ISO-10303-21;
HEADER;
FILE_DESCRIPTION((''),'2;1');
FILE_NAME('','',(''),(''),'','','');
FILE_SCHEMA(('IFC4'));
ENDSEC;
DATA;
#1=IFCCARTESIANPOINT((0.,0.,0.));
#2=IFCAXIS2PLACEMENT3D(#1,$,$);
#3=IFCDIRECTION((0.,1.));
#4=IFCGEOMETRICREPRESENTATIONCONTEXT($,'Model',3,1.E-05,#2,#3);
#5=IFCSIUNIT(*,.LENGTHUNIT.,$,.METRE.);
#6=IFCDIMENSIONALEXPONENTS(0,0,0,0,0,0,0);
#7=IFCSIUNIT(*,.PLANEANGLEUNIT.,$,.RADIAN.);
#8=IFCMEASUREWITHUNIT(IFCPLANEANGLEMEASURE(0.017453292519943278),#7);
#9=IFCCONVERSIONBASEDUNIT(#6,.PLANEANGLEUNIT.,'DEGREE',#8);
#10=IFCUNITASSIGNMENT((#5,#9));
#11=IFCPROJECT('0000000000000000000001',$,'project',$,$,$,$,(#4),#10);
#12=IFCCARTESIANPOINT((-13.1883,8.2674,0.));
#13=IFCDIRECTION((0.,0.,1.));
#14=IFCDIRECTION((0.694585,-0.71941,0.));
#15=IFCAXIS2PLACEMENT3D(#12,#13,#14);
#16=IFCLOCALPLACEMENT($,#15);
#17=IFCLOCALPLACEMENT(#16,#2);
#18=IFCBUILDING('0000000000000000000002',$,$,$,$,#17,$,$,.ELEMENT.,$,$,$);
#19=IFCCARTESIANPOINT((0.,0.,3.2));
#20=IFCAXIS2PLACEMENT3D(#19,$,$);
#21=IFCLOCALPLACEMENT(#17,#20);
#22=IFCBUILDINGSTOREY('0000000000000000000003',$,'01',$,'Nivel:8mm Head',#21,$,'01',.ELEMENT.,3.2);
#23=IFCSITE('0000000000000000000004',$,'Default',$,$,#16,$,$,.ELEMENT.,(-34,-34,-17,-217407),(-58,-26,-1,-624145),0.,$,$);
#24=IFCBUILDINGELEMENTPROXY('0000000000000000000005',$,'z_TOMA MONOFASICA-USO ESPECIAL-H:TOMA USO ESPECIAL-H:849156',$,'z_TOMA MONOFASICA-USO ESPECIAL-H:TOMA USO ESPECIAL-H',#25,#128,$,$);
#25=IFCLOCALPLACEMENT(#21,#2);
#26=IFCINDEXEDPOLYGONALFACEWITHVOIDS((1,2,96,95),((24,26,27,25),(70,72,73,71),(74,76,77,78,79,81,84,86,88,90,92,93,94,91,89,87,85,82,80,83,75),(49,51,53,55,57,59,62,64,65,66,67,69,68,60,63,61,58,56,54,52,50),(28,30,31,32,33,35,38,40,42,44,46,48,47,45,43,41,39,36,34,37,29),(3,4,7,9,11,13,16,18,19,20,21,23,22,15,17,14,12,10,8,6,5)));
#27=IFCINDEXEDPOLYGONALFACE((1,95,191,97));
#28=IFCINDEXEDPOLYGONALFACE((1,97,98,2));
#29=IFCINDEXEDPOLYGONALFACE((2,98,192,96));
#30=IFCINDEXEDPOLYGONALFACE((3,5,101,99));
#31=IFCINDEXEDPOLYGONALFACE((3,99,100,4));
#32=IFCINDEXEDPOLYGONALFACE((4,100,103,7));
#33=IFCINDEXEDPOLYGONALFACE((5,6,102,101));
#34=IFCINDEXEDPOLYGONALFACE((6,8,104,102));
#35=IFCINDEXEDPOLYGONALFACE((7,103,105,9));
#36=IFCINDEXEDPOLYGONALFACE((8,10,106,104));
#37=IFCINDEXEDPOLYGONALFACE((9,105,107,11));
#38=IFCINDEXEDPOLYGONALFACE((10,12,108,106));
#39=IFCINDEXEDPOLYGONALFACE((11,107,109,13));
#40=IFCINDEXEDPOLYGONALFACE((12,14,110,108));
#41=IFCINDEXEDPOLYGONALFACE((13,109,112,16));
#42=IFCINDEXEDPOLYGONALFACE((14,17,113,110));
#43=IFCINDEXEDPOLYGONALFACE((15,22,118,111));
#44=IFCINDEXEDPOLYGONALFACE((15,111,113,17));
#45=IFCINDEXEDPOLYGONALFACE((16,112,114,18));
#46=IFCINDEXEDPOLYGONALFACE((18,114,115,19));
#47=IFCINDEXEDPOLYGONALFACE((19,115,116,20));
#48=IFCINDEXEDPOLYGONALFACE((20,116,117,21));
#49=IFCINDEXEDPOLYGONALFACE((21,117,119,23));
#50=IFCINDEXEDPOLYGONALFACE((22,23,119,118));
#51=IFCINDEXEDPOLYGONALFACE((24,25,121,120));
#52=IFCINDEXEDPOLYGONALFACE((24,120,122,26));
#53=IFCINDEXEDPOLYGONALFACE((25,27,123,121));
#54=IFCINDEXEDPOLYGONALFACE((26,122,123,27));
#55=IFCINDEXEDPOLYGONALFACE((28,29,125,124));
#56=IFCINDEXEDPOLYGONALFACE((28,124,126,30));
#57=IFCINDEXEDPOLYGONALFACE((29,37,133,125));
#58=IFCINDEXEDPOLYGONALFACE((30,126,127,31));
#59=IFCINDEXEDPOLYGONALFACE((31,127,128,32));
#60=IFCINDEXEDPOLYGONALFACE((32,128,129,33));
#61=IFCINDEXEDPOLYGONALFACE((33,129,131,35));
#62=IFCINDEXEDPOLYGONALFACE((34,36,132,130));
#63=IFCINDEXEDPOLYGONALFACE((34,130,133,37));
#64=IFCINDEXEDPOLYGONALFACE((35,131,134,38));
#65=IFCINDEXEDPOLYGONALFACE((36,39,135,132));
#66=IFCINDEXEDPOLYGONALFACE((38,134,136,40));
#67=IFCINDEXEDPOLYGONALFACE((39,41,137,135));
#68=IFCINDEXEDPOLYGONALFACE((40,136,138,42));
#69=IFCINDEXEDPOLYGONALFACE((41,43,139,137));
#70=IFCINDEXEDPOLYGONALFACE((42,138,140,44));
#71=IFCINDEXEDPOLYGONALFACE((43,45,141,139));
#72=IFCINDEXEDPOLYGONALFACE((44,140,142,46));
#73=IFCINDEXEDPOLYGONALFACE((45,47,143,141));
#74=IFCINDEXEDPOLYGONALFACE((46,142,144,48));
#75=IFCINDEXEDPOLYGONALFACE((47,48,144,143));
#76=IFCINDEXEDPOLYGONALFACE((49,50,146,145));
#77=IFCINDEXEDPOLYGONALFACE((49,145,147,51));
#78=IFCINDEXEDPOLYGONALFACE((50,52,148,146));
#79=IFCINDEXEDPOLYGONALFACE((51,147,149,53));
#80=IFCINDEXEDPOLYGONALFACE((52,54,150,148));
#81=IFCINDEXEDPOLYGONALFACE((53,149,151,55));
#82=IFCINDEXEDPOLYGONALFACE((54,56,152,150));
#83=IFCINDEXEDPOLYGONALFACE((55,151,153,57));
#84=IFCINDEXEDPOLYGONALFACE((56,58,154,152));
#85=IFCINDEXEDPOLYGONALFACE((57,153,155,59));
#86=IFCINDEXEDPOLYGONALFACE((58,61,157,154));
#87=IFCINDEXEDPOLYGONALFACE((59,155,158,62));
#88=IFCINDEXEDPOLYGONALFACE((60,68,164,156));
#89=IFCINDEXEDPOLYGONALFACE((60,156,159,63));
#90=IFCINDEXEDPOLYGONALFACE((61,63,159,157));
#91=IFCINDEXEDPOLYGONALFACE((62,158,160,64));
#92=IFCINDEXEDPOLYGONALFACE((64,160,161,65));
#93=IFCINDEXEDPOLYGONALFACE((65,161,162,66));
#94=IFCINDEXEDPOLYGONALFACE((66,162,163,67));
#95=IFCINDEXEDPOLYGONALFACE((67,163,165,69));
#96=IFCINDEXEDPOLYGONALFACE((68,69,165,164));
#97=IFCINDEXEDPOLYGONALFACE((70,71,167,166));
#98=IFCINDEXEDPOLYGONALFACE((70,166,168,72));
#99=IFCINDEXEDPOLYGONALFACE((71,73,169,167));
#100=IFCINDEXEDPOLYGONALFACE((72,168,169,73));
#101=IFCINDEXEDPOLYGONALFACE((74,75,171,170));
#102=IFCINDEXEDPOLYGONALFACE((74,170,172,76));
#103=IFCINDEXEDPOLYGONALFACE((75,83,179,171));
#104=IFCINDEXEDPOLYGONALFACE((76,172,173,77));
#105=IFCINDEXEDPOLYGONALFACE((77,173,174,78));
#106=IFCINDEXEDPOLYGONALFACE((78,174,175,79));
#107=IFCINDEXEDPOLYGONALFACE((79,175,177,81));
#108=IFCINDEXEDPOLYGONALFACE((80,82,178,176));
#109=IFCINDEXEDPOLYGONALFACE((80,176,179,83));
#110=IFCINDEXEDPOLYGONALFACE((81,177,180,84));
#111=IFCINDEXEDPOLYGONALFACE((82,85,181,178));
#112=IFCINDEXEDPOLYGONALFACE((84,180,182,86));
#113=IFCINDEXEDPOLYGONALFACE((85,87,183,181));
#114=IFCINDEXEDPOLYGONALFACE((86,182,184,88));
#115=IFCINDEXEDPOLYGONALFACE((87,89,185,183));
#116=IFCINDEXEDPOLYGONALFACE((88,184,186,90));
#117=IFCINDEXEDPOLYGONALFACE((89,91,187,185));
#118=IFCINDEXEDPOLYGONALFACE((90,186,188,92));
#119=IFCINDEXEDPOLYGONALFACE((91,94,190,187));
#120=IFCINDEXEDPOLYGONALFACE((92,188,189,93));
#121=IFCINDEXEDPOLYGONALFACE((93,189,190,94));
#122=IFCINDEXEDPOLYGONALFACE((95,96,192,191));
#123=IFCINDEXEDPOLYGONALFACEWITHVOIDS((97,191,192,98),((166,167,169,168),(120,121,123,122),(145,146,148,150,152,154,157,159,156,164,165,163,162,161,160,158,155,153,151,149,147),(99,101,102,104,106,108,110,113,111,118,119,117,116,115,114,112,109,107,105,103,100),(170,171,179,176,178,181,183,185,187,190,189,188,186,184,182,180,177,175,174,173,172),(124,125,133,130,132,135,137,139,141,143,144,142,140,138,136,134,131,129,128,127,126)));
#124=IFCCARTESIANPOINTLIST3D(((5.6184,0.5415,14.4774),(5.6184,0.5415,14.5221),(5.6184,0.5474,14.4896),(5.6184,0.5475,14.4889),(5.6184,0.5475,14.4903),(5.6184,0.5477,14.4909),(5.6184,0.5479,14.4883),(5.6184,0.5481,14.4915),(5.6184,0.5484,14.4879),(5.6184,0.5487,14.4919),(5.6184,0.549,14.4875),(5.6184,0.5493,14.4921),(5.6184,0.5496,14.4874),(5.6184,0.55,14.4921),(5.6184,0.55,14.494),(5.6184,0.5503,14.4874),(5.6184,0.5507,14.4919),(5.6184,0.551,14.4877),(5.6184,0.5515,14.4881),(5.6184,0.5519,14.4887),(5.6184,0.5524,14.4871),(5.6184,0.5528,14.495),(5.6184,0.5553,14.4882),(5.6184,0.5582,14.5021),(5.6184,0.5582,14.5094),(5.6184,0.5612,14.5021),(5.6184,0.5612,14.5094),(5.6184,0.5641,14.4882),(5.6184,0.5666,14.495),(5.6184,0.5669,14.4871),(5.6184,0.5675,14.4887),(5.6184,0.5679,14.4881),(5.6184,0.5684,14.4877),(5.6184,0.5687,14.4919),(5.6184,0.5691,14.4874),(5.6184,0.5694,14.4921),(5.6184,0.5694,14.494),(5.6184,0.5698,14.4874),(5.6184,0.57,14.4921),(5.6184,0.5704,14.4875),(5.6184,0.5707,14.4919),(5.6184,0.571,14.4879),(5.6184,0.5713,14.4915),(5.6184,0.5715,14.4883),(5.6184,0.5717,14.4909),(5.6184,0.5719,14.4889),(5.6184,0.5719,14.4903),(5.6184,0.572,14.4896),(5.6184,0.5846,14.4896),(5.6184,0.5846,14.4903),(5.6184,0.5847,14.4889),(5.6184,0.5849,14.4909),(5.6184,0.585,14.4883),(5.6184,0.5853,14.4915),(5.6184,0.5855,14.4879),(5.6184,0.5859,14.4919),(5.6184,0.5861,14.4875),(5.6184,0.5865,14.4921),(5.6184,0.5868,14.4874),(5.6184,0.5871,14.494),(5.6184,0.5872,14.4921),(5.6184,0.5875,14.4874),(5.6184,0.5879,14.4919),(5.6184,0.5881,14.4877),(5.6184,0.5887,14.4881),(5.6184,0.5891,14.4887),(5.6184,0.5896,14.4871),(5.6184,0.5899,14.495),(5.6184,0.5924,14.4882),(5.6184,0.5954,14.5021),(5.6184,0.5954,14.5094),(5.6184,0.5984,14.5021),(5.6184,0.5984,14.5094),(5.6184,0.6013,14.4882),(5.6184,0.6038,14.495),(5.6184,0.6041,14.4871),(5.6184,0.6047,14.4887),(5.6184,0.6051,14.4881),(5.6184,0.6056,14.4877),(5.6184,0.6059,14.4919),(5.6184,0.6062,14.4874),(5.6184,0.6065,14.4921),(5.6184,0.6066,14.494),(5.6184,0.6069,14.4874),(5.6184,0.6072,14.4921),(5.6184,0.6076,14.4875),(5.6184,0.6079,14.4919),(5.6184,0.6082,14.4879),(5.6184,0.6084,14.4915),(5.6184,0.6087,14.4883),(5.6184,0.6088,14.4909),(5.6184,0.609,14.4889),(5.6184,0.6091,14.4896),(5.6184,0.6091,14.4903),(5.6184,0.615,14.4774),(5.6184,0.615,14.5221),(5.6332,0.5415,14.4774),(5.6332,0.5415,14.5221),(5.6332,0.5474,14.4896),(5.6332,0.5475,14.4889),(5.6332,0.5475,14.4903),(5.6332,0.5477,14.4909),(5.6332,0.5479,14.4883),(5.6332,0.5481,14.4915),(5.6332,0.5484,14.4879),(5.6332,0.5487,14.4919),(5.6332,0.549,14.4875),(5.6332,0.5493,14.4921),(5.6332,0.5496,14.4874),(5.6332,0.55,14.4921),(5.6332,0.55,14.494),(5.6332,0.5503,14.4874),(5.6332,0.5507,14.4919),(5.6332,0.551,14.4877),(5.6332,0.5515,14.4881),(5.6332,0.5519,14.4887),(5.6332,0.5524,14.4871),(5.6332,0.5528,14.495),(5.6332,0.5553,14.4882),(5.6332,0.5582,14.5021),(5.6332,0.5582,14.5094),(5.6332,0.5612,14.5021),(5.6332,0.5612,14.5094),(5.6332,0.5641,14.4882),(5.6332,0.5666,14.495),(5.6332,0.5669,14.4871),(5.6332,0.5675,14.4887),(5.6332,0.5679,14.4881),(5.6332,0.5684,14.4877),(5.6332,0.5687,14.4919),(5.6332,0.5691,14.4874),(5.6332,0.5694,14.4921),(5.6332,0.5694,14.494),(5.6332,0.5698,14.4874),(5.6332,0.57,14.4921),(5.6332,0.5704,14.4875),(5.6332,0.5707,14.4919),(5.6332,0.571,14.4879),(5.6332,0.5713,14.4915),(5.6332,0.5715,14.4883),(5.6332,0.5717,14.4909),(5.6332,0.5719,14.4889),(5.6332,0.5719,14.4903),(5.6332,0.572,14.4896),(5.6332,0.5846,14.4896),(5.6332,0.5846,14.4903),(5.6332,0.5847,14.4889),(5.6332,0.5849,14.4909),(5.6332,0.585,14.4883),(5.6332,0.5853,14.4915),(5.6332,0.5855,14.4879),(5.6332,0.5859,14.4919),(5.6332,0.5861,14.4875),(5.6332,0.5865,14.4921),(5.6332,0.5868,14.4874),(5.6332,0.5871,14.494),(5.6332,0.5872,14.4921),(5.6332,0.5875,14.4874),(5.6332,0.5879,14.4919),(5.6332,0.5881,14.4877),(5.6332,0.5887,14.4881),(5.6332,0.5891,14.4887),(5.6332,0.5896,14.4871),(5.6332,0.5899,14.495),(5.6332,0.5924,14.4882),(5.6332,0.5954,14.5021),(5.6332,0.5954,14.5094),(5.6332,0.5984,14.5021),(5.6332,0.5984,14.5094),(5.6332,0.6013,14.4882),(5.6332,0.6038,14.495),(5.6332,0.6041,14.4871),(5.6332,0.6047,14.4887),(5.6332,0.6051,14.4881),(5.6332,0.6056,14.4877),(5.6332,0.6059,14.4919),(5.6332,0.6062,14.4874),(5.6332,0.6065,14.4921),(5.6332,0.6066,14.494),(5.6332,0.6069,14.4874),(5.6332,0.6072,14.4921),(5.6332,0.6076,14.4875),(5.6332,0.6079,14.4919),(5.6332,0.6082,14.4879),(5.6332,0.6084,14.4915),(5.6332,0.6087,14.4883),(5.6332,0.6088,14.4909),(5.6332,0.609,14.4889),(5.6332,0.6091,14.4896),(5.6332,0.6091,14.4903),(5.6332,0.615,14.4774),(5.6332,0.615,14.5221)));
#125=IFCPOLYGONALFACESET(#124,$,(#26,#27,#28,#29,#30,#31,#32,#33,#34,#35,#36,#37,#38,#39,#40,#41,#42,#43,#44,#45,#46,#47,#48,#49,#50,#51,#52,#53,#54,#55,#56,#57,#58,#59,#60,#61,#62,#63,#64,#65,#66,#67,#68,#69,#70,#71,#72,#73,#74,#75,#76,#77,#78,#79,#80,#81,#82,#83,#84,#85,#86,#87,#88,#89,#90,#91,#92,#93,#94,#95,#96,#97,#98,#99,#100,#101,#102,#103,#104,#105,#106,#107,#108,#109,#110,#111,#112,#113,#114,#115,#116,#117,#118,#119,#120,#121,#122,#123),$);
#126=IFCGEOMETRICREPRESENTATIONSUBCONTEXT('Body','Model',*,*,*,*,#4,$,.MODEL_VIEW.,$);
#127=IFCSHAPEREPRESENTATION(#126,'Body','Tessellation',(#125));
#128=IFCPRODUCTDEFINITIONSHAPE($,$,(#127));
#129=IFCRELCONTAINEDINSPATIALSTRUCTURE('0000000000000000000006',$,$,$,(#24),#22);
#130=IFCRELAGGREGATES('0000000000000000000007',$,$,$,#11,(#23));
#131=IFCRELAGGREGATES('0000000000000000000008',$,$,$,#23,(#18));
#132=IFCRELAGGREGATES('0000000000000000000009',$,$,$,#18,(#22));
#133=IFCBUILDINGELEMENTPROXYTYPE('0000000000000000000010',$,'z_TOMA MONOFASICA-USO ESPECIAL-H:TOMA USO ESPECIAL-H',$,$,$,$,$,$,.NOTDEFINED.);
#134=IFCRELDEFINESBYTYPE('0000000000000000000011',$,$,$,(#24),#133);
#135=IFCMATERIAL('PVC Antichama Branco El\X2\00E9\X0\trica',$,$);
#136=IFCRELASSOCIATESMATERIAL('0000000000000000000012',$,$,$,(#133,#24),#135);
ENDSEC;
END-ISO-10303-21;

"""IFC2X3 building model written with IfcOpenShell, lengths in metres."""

from ifc_helpers import new_model, entity, si_unit, converted_unit, direction, frame, frame_2d, origin, place, context, subcontext, project, spatial, polyline, circle_curve, parameter, trimmed, segment, composite_curve, outline, extrude, source, transform, mapped, material, type_object, type_shapes, element, save


model = new_model("IFC2X3")

# Units and contexts
model_context = context("Model", 3, precision=1e-05, world=origin(), true_north=direction((0.0, 1.0)))
body_context = subcontext(model_context, "Body", "Model", "MODEL_VIEW")
ifc_project = project(units=[si_unit("LENGTHUNIT", "METRE"), converted_unit("PLANEANGLEUNIT", "DEGREE", entity("IfcPlaneAngleMeasure", 0.017453292519943278), si_unit("PLANEANGLEUNIT", "RADIAN"), dimensions=[0, 0, 0, 0, 0, 0, 0])], contexts=[model_context])

# Site, building, storey
site_placement = place(None, frame((-13.1883, 8.2674, 0.0), z_axis=(0.0, 0.0, 1.0), x_axis=(0.694585, -0.71941, 0.0)))
site = spatial("IfcSite", under=ifc_project, at=site_placement, Name="Default", CompositionType="ELEMENT", RefLatitude=(-34, -34, -17, -217407), RefLongitude=(-58, -26, -1, -624145), RefElevation=0.0)
building_placement = place(site_placement, origin())
building = spatial("IfcBuilding", under=site, at=building_placement, CompositionType="ELEMENT")
storey_placement = place(building_placement, frame((0.0, 0.0, 3.2)))
storey = spatial("IfcBuildingStorey", under=building, at=storey_placement, Name="01", ObjectType="Nivel:8mm Head", LongName="01", CompositionType="ELEMENT", Elevation=3.2)

# Building element proxy
ifc_material_1 = material(Name="PVC Antichama Branco Elétrica")
building_element_proxy_type_1 = type_object("IfcBuildingElementProxyType", Name="z_TOMA MONOFASICA-USO ESPECIAL-H:TOMA USO ESPECIAL-H", PredefinedType="NOTDEFINED", material=ifc_material_1)
shared_shape_1 = source(origin(), body_context, "Body", "SweptSolid", [
    extrude(outline(polyline([(-0.0368, -0.0223), (0.0368, -0.0223), (0.0368, 0.0223), (-0.0368, 0.0223), (-0.0368, -0.0223)]), holes=[composite_curve([segment(polyline([(0.0141, 0.0115), (0.0116, 0.0047)]), True, "CONTINUOUS"), segment(polyline([(0.0116, 0.0047), (0.0088, 0.0057)]), True, "CONTINUOUS"), segment(polyline([(0.0088, 0.0057), (0.0096, 0.0078)]), True, "CONTINUOUS"), segment(trimmed(circle_curve(frame_2d((0.0087, 0.0099), x_axis=(1.0, 0.0)), 0.0024), [parameter(27.118901)], [parameter(292.881099)], True, "PARAMETER"), False, "CONTINUOUS"), segment(polyline([(0.0108, 0.011), (0.0113, 0.0126)]), True, "CONTINUOUS"), segment(polyline([(0.0113, 0.0126), (0.0141, 0.0115)]), True, "CONTINUOUS")], self_intersect=False), composite_curve([segment(polyline([(0.0255, 0.0047), (0.023, 0.0115)]), True, "CONTINUOUS"), segment(polyline([(0.023, 0.0115), (0.0258, 0.0126)]), True, "CONTINUOUS"), segment(polyline([(0.0258, 0.0126), (0.0264, 0.011)]), True, "CONTINUOUS"), segment(trimmed(circle_curve(frame_2d((0.0285, 0.0099), x_axis=(1.0, 0.0)), 0.0024), [parameter(247.118901)], [parameter(152.881099)], True, "PARAMETER"), False, "CONTINUOUS"), segment(polyline([(0.0276, 0.0078), (0.0283, 0.0057)]), True, "CONTINUOUS"), segment(polyline([(0.0283, 0.0057), (0.0255, 0.0047)]), True, "CONTINUOUS")], self_intersect=False), polyline([(0.0201, -0.0024), (0.0201, -0.0097), (0.0171, -0.0097), (0.0171, -0.0024), (0.0201, -0.0024)]), composite_curve([segment(polyline([(-0.0141, 0.0115), (-0.0113, 0.0126)]), True, "CONTINUOUS"), segment(polyline([(-0.0113, 0.0126), (-0.0108, 0.011)]), True, "CONTINUOUS"), segment(trimmed(circle_curve(frame_2d((-0.0087, 0.0099), x_axis=(1.0, 0.0)), 0.0024), [parameter(247.118901)], [parameter(152.881099)], True, "PARAMETER"), False, "CONTINUOUS"), segment(polyline([(-0.0096, 0.0078), (-0.0088, 0.0057)]), True, "CONTINUOUS"), segment(polyline([(-0.0088, 0.0057), (-0.0116, 0.0047)]), True, "CONTINUOUS"), segment(polyline([(-0.0116, 0.0047), (-0.0141, 0.0115)]), True, "CONTINUOUS")], self_intersect=False), composite_curve([segment(polyline([(-0.0255, 0.0047), (-0.0283, 0.0057)]), True, "CONTINUOUS"), segment(polyline([(-0.0283, 0.0057), (-0.0276, 0.0078)]), True, "CONTINUOUS"), segment(trimmed(circle_curve(frame_2d((-0.0285, 0.0099), x_axis=(1.0, 0.0)), 0.0024), [parameter(27.118901)], [parameter(292.881099)], True, "PARAMETER"), False, "CONTINUOUS"), segment(polyline([(-0.0264, 0.011), (-0.0258, 0.0126)]), True, "CONTINUOUS"), segment(polyline([(-0.0258, 0.0126), (-0.023, 0.0115)]), True, "CONTINUOUS"), segment(polyline([(-0.023, 0.0115), (-0.0255, 0.0047)]), True, "CONTINUOUS")], self_intersect=False), polyline([(-0.0201, -0.0024), (-0.0171, -0.0024), (-0.0171, -0.0097), (-0.0201, -0.0097), (-0.0201, -0.0024)])]), frame((0.0, -0.005, 0.0223), z_axis=(0.0, 1.0, 0.0), x_axis=(1.0, 0.0, 0.0)), (0.0, 0.0, 1.0), 0.0148),
])
type_shapes(building_element_proxy_type_1, [shared_shape_1])
for number, where, z_axis, x_axis, name in (
    (1, (5.6282, 0.5783, 14.4774), (0.0, 0.0, 1.0), (0.0, 1.0, 0.0), "z_TOMA MONOFASICA-USO ESPECIAL-H:TOMA USO ESPECIAL-H:849156"),
):
    element("IfcBuildingElementProxy", number, at=place(storey_placement, frame(where, z_axis=z_axis, x_axis=x_axis)), inside=storey, type_object=building_element_proxy_type_1, material=ifc_material_1, Name=name, ObjectType="z_TOMA MONOFASICA-USO ESPECIAL-H:TOMA USO ESPECIAL-H", context=body_context, shape_type="MappedRepresentation", body=[
        mapped(shared_shape_1, transform((0.0, 0.0, 0.0), scale=1.0)),
    ])

save(model, "model.ifc")
